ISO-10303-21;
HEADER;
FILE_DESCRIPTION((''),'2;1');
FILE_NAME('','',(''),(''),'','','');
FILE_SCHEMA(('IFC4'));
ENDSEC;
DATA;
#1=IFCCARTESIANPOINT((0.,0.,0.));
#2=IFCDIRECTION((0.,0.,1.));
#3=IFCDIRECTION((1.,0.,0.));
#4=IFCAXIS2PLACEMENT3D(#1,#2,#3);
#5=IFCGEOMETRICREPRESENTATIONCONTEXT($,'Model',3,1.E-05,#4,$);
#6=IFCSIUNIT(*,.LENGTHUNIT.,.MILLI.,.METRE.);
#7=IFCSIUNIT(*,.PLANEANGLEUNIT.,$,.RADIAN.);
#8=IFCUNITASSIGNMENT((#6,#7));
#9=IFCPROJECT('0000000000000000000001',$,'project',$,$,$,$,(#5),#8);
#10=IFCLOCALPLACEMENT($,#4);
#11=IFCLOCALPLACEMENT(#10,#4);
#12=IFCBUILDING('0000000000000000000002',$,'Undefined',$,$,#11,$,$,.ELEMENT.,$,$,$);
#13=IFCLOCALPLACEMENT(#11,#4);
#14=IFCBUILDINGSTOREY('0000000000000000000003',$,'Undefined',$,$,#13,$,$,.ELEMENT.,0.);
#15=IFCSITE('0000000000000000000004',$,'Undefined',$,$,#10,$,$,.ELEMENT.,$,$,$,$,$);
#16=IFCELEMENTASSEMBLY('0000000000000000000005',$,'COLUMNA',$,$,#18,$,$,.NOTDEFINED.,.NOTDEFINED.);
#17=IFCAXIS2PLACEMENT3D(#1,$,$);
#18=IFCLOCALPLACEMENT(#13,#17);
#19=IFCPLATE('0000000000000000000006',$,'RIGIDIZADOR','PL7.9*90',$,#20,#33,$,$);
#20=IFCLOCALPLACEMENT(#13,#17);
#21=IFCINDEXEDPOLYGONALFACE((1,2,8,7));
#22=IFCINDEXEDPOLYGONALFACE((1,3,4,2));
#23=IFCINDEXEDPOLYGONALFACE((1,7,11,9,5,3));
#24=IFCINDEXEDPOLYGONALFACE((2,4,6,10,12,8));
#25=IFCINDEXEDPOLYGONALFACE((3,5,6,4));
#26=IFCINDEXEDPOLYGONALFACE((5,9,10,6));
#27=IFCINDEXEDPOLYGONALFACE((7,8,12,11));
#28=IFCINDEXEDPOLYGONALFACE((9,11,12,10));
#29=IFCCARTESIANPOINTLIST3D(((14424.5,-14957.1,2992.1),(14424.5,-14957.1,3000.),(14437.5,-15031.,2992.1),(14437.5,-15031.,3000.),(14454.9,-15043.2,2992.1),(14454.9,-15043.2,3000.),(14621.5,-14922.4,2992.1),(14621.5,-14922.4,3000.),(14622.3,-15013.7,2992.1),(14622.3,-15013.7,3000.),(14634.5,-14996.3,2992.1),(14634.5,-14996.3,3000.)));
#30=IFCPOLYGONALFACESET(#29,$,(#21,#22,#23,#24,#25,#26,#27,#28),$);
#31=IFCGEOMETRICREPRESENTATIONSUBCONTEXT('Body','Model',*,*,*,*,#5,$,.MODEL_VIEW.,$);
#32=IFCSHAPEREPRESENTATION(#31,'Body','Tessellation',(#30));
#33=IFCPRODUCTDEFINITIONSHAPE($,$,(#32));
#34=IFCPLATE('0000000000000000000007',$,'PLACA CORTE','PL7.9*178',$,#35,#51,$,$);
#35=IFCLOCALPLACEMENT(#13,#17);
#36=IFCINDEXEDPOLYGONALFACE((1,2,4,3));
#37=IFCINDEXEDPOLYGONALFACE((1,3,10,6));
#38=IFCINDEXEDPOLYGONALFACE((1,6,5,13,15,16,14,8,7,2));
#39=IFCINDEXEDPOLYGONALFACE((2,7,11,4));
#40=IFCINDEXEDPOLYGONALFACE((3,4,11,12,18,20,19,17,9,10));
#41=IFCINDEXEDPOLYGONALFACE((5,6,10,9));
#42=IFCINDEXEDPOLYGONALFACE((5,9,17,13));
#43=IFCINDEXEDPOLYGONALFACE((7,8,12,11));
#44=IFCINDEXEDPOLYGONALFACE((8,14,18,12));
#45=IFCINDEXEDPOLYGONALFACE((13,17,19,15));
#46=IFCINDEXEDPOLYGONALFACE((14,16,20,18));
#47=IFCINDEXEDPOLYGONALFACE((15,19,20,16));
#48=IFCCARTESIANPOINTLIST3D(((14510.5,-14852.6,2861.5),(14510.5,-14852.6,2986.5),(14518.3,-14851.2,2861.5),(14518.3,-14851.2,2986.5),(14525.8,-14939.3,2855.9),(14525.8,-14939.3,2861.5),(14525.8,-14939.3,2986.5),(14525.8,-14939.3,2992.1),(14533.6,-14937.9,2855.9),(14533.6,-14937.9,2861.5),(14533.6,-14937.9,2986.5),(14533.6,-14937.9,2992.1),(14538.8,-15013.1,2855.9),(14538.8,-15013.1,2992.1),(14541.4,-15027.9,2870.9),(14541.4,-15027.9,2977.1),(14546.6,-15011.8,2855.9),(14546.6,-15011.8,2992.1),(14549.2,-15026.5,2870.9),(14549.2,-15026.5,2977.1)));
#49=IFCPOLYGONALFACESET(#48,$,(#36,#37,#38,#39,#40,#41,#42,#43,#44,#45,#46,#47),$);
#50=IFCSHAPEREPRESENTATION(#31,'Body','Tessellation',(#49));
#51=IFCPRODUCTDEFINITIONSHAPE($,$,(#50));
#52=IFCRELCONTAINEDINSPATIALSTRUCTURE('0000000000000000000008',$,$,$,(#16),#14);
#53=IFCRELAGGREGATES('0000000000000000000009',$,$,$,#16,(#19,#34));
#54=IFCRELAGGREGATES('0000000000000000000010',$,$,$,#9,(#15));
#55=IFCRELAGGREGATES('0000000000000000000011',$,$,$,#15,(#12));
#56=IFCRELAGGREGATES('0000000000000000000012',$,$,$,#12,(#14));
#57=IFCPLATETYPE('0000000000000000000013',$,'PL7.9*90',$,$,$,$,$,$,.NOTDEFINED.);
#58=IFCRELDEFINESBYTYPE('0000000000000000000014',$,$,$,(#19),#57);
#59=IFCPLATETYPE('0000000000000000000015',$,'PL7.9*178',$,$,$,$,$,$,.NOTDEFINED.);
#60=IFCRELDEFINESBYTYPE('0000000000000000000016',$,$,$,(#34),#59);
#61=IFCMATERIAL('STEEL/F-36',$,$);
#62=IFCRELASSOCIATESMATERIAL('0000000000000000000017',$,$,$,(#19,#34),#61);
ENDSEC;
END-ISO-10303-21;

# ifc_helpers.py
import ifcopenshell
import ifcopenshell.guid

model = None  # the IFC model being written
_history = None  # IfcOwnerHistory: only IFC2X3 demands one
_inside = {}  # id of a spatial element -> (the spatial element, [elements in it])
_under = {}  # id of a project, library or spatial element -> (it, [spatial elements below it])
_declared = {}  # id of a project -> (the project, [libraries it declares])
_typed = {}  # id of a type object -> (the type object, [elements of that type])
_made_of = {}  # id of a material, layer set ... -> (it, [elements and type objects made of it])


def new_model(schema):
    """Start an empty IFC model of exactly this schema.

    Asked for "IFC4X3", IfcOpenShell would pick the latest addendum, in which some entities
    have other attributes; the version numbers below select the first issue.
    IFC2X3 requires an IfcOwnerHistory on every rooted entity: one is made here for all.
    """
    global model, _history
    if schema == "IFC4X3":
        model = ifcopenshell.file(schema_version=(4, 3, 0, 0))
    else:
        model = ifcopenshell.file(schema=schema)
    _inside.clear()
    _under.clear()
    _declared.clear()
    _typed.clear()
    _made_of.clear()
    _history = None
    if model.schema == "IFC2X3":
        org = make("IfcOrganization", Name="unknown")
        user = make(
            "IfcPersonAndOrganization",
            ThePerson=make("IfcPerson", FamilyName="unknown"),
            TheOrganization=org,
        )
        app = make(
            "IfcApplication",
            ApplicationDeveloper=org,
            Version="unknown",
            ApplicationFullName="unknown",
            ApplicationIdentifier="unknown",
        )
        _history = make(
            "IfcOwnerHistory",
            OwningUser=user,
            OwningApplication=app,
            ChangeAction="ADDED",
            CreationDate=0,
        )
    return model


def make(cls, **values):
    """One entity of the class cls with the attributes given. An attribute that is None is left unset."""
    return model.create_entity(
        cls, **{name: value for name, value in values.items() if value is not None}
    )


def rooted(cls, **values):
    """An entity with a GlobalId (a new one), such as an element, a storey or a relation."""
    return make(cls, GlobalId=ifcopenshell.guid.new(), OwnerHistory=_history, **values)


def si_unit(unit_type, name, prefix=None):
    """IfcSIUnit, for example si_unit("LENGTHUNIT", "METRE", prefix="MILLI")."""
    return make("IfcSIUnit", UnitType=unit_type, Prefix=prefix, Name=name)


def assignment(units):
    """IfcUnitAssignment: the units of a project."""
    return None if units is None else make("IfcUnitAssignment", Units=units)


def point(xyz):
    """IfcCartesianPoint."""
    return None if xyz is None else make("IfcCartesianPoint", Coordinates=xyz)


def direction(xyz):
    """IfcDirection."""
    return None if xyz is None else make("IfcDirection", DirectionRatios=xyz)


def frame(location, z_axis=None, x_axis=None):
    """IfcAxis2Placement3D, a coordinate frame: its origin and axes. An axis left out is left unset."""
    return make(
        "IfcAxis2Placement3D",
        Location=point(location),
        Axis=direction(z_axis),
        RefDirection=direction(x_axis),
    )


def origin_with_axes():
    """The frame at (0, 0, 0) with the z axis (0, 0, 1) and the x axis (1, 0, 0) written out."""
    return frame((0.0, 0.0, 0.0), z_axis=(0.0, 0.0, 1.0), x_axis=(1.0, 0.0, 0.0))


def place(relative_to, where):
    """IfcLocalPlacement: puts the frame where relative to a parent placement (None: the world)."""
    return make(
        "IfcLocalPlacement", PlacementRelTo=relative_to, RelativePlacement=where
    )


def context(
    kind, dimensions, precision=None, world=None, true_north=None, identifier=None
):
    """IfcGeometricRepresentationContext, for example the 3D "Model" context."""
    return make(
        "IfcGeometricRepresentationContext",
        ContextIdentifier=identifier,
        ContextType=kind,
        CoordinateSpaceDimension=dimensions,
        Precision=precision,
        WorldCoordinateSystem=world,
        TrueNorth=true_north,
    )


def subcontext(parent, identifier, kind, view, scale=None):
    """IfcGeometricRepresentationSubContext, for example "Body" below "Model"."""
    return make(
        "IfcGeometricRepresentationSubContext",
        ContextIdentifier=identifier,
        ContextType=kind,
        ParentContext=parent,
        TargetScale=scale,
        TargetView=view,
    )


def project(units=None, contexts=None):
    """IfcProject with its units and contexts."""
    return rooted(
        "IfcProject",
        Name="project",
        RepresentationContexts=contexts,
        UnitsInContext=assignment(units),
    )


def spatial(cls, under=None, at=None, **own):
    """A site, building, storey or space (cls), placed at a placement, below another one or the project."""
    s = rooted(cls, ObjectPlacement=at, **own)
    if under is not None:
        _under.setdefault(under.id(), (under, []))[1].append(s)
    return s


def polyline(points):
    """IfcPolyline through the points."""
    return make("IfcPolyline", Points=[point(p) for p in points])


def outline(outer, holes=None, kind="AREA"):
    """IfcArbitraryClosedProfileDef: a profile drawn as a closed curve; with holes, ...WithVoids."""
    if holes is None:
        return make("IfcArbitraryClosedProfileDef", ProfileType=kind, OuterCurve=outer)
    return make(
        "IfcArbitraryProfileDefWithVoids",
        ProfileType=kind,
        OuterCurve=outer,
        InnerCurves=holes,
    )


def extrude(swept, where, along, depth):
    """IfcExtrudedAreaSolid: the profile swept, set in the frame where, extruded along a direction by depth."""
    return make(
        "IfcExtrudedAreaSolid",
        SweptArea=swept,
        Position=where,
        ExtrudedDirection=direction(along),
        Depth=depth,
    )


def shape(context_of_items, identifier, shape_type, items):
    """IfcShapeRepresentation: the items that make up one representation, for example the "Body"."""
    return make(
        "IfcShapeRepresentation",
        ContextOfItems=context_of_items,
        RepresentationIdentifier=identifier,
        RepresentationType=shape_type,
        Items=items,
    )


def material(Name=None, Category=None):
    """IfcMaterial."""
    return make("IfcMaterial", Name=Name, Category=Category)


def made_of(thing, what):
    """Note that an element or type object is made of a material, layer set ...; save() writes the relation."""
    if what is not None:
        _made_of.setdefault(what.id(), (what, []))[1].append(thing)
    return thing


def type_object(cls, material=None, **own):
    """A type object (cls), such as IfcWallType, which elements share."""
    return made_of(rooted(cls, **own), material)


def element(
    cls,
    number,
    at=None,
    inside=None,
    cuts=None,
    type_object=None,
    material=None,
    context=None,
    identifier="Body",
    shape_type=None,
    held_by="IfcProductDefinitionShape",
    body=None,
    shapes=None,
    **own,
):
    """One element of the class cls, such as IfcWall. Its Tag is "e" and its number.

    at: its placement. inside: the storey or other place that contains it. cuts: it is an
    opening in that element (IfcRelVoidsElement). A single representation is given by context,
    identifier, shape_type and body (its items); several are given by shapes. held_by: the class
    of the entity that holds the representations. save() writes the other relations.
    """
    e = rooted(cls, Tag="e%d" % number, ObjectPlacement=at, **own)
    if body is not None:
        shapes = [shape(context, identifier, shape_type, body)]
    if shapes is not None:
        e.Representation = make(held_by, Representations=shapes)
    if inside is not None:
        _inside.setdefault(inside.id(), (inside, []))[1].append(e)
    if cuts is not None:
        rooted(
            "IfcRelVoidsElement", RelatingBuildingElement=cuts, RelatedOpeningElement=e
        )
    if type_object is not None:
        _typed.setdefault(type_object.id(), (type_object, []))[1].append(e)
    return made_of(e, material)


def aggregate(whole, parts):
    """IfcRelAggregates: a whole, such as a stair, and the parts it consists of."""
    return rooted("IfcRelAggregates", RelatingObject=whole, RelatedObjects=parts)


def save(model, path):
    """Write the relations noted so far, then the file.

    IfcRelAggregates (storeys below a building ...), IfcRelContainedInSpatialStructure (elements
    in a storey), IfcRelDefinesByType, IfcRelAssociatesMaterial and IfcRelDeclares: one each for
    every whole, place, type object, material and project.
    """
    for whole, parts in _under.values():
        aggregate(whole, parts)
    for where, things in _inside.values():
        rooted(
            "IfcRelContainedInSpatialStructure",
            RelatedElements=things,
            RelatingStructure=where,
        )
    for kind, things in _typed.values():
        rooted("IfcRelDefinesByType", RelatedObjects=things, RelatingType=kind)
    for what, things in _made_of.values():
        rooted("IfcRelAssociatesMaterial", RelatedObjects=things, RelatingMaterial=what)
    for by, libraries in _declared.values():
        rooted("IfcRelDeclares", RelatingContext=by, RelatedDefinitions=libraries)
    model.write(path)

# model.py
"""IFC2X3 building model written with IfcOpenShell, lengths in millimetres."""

from ifc_helpers import new_model, si_unit, frame, origin_with_axes, place, context, subcontext, project, spatial, polyline, outline, extrude, material, type_object, element, aggregate, save


model = new_model("IFC2X3")

# Units and contexts
model_context = context("Model", 3, precision=1e-05, world=origin_with_axes())
body_context = subcontext(model_context, "Body", "Model", "MODEL_VIEW")
ifc_project = project(units=[si_unit("LENGTHUNIT", "METRE", prefix="MILLI"), si_unit("PLANEANGLEUNIT", "RADIAN")], contexts=[model_context])

# Site, building, storey
site_placement = place(None, origin_with_axes())
site = spatial("IfcSite", under=ifc_project, at=site_placement, Name="Undefined", CompositionType="ELEMENT")
building_placement = place(site_placement, origin_with_axes())
building = spatial("IfcBuilding", under=site, at=building_placement, Name="Undefined", CompositionType="ELEMENT")
storey_placement = place(building_placement, origin_with_axes())
storey = spatial("IfcBuildingStorey", under=building, at=storey_placement, Name="Undefined", CompositionType="ELEMENT", Elevation=0.0)

# Shared definitions
ifc_material_1 = material(Name="STEEL/F-36")

# Element assembly
assembly_1_placement = place(storey_placement, origin_with_axes())
assembly_1 = element("IfcElementAssembly", 1, at=assembly_1_placement, inside=storey, Name="COLUMNA", AssemblyPlace="NOTDEFINED", PredefinedType="NOTDEFINED")

# Plates
plate_type_1 = type_object("IfcPlateType", Name="PL7.9*90", PredefinedType="NOTDEFINED")
plate_1_placement = place(assembly_1_placement, frame((14637.1, -15011.1, 2996.1), z_axis=(0.0, 0.0, 1.0), x_axis=(-0.173649, 0.984808, 0.0)))
plate_1 = element("IfcPlate", 2, at=plate_1_placement, type_object=plate_type_1, material=ifc_material_1, Name="RIGIDIZADOR", Description="PL7.9*90", context=body_context, shape_type="SweptSolid", body=[
    extrude(outline(polyline([(0.0, 15.0), (15.0, 0.0), (90.0, 0.0), (90.0, 200.0), (15.0, 200.0), (0.0, 185.0), (0.0, 15.0)])), frame((0.0, 0.0, -4.0), z_axis=(0.0, 0.0, 1.0), x_axis=(1.0, 0.0, 0.0)), (0.0, 0.0, 1.0), 7.9),
])
plate_type_2 = type_object("IfcPlateType", Name="PL7.9*178", PredefinedType="NOTDEFINED")
plate_2_placement = place(assembly_1_placement, frame((14545.3, -15027.2, 2992.1), z_axis=(0.984808, 0.173649, 0.0), x_axis=(0.0, 0.0, -1.0)))
plate_2 = element("IfcPlate", 3, at=plate_2_placement, type_object=plate_type_2, material=ifc_material_1, Name="PLACA CORTE", Description="PL7.9*178", context=body_context, shape_type="SweptSolid", body=[
    extrude(outline(polyline([(0.0, 15.0), (15.0, 0.0), (121.2, 0.0), (136.2, 15.0), (136.2, 90.0), (130.6, 90.0), (130.6, 178.0), (5.6, 178.0), (5.6, 90.0), (0.0, 90.0), (0.0, 15.0)])), frame((0.0, 0.0, -4.0), z_axis=(0.0, 0.0, 1.0), x_axis=(1.0, 0.0, 0.0)), (0.0, 0.0, 1.0), 7.9),
])

aggregate(assembly_1, [plate_1, plate_2])

save(model, "model.ifc")
